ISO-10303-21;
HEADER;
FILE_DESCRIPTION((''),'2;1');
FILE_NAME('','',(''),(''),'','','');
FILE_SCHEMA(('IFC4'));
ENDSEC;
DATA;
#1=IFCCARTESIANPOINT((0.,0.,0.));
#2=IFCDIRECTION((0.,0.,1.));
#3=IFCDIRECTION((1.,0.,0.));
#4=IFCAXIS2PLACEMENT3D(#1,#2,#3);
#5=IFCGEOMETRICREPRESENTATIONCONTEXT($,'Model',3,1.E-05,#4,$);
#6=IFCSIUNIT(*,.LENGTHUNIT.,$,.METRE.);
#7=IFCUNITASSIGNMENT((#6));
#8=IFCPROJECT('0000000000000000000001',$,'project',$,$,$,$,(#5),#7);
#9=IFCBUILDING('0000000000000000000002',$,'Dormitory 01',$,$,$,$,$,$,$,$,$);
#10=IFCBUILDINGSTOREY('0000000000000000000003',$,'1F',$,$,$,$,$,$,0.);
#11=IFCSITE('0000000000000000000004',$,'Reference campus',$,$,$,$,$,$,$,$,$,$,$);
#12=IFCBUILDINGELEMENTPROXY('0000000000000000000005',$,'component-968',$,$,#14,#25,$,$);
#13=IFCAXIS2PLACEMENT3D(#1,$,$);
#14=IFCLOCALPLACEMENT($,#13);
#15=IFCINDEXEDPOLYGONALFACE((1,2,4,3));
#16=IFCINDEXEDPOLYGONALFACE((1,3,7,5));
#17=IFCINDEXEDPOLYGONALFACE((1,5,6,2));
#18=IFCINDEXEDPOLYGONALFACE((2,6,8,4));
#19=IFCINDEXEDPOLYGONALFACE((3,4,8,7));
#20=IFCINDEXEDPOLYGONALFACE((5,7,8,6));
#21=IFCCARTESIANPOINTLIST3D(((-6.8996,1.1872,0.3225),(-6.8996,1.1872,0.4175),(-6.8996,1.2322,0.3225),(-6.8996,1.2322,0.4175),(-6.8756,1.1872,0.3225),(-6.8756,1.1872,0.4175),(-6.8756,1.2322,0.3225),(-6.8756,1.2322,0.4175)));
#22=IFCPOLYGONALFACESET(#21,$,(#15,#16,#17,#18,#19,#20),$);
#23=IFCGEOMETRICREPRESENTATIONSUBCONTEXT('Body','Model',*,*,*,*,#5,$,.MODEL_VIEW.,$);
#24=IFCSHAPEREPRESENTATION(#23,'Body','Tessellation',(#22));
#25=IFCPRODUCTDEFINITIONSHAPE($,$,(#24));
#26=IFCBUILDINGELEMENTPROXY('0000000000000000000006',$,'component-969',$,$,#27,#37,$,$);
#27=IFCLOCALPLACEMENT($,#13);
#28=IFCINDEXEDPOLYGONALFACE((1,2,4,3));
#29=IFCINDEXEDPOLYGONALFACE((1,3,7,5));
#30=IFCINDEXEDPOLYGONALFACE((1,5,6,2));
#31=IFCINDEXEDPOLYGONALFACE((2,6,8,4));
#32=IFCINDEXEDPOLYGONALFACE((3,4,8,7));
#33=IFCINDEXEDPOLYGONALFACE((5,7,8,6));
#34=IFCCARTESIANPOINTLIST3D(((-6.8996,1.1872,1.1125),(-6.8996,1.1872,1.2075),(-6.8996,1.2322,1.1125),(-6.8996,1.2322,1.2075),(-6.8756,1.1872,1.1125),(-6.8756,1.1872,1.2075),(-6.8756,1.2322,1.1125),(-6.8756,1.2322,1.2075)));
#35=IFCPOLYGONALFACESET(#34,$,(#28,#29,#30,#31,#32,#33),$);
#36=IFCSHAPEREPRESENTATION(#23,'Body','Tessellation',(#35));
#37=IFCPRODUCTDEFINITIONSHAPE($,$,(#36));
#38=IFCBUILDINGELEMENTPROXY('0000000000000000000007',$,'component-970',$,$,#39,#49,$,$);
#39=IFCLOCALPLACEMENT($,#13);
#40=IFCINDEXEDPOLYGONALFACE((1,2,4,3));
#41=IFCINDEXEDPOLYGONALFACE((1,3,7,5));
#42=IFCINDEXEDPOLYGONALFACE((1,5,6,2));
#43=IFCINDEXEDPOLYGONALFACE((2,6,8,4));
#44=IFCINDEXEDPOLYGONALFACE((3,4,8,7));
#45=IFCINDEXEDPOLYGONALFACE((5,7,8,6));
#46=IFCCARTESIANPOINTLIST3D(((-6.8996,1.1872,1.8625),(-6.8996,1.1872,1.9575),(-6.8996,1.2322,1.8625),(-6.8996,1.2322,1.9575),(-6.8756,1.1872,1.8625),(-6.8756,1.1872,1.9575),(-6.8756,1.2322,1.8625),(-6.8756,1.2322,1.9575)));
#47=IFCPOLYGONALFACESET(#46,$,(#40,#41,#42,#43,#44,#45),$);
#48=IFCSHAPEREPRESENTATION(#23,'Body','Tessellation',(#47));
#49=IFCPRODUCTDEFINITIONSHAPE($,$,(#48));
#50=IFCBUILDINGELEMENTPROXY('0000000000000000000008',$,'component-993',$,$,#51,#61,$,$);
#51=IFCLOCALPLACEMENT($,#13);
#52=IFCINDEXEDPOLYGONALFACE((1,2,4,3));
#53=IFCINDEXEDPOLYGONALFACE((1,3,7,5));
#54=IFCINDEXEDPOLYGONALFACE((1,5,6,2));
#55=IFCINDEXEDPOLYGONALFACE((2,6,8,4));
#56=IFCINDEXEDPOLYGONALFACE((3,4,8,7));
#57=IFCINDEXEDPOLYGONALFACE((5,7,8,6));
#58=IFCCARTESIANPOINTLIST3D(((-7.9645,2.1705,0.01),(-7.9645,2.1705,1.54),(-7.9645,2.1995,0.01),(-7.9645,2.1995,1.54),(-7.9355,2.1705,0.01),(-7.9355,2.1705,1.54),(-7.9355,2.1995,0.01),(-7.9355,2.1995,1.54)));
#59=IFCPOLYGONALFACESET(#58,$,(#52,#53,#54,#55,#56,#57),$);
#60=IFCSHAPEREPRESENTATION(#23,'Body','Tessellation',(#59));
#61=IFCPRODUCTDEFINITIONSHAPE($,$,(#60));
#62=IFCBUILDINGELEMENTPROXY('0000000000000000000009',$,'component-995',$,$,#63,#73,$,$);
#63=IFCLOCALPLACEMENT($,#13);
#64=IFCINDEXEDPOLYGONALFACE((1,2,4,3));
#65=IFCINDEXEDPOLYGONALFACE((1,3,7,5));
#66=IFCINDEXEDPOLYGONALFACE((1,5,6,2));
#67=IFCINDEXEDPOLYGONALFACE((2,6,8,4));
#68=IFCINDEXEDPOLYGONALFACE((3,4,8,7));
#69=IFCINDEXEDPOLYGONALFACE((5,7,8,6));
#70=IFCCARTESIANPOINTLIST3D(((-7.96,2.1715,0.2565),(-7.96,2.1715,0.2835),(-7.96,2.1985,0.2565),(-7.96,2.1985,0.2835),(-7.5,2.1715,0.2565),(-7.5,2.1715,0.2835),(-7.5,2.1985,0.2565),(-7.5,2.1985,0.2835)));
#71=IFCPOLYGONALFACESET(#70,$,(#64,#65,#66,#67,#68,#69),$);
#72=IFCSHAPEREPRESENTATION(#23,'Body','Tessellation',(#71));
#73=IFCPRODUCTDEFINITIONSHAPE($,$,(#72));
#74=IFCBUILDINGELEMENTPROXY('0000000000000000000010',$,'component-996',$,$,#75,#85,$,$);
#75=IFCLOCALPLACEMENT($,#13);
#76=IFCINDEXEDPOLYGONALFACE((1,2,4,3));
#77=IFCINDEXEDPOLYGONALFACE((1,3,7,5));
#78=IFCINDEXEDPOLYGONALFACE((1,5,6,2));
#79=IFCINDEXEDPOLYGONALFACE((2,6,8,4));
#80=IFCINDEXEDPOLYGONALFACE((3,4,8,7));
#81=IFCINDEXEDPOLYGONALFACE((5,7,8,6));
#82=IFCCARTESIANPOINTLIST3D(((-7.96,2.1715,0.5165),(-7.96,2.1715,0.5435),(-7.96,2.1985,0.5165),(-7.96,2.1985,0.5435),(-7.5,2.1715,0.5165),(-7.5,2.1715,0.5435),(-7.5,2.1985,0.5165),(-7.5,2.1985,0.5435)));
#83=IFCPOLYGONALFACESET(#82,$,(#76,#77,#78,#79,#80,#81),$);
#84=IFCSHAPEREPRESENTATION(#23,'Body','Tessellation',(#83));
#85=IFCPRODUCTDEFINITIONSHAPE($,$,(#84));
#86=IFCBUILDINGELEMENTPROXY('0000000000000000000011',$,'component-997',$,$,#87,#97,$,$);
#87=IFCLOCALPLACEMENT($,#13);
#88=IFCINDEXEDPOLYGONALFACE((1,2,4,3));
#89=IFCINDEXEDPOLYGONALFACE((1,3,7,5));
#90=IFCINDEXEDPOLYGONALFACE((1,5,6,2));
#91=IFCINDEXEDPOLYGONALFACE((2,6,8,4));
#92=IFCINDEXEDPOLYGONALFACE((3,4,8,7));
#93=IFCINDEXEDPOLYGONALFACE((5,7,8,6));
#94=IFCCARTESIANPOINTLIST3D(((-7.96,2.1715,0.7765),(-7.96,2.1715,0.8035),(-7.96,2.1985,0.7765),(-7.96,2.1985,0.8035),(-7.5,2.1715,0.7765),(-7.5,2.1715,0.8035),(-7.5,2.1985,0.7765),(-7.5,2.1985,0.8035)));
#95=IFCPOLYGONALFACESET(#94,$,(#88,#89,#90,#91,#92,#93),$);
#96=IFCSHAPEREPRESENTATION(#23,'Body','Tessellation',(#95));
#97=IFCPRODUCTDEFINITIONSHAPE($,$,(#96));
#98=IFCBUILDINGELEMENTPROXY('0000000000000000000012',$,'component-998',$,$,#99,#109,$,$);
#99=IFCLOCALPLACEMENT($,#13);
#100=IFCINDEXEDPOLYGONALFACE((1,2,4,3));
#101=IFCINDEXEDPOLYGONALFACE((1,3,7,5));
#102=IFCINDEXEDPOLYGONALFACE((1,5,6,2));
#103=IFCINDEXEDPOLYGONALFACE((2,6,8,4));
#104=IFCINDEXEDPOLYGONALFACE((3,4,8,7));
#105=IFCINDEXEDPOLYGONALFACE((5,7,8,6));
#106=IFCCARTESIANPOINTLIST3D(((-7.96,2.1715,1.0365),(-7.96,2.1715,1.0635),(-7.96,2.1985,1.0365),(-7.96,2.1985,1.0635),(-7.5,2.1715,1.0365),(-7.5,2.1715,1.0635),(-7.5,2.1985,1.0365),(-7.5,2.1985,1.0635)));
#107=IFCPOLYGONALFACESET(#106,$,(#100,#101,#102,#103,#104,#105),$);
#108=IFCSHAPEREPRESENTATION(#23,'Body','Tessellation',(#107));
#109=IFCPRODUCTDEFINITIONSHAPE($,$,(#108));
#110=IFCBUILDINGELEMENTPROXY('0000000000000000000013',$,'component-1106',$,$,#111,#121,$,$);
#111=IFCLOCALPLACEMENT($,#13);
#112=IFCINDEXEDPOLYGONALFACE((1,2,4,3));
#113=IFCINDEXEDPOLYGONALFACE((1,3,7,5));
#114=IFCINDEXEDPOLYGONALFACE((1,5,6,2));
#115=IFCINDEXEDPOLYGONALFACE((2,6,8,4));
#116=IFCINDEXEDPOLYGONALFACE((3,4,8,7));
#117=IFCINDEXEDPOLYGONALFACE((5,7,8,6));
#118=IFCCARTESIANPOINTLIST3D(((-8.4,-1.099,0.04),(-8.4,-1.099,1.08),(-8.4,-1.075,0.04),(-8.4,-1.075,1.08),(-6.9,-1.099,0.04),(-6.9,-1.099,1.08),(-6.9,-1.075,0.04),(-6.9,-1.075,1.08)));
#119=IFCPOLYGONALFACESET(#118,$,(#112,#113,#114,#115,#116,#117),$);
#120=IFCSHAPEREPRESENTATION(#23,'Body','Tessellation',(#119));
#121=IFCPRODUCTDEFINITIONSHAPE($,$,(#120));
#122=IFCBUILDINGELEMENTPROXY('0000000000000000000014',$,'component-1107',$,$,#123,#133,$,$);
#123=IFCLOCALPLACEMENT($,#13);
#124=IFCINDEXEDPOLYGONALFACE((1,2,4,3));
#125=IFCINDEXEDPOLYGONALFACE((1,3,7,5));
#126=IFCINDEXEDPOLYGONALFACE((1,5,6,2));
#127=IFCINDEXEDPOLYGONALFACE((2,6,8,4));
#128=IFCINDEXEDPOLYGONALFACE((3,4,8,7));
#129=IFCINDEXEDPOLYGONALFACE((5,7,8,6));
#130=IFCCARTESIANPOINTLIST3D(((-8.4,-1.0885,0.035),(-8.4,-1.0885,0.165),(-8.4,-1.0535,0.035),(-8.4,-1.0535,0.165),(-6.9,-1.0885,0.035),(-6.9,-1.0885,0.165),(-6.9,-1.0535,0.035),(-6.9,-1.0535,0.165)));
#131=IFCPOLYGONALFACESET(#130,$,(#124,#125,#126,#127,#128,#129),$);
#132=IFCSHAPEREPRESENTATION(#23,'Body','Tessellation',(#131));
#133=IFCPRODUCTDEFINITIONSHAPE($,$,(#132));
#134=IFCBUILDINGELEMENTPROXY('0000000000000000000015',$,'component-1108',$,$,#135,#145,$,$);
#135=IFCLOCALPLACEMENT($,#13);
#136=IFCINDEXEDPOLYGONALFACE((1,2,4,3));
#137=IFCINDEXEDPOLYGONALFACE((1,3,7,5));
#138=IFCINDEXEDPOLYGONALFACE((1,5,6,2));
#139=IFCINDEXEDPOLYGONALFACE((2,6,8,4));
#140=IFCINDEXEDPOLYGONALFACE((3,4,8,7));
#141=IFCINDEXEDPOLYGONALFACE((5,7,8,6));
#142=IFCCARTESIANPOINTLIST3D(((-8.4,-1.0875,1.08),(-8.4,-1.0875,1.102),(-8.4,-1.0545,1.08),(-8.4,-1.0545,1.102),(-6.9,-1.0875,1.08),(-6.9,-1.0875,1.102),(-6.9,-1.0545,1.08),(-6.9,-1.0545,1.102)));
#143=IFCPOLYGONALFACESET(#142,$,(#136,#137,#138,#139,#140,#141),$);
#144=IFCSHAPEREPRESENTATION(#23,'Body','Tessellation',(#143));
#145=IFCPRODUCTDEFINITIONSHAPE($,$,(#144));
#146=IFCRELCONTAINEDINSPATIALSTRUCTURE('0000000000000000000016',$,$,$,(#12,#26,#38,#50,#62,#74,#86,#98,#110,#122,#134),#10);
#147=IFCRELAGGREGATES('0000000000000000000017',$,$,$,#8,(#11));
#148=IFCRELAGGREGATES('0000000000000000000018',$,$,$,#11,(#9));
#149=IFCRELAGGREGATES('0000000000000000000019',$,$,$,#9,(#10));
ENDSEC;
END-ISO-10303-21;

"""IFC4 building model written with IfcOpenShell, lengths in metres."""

from ifc_helpers import new_model, si_unit, frame, origin, origin_with_axes, origin_2d, place, context, subcontext, project, spatial, rectangle, extrude, element, save


model = new_model("IFC4")

# Units and contexts
model_context = context("Model", 3, precision=1e-05, world=origin_with_axes())
body_context = subcontext(model_context, "Body", "Model", "MODEL_VIEW")
ifc_project = project(units=[si_unit("LENGTHUNIT", "METRE")], contexts=[model_context])

# Site, building, storey
site = spatial("IfcSite", under=ifc_project, Name="Reference campus")
building = spatial("IfcBuilding", under=site, Name="Dormitory 01")
storey = spatial("IfcBuildingStorey", under=building, Name="1F", Elevation=0.0)

# Building element proxies
for number, where, z_axis, x_axis, name in (
    (1, (-6.8876, 1.2097, 0.3225), (0.0, 0.0, 1.0), (1.0, 0.0, 0.0), "component-968"),
    (2, (-6.8876, 1.2097, 1.1125), (0.0, 0.0, 1.0), (1.0, 0.0, 0.0), "component-969"),
    (3, (-6.8876, 1.2097, 1.8625), (0.0, 0.0, 1.0), (1.0, 0.0, 0.0), "component-970"),
):
    element("IfcBuildingElementProxy", number, at=place(None, frame(where, z_axis=z_axis, x_axis=x_axis)), inside=storey, Name=name, context=body_context, shape_type="SweptSolid", body=[
        extrude(rectangle(XDim=0.024, YDim=0.045, at=origin_2d()), origin(), (0.0, 0.0, 1.0), 0.095),
    ])
proxy_1_placement = place(None, frame((-7.95, 2.185, 0.01), z_axis=(0.0, 0.0, 1.0), x_axis=(1.0, 0.0, 0.0)))
element("IfcBuildingElementProxy", 4, at=proxy_1_placement, inside=storey, Name="component-993", context=body_context, shape_type="SweptSolid", body=[
    extrude(rectangle(XDim=0.029, YDim=0.029, at=origin_2d()), origin(), (0.0, 0.0, 1.0), 1.53),
])
for number, where, z_axis, x_axis, name in (
    (5, (-7.73, 2.185, 0.2565), (0.0, 0.0, 1.0), (1.0, 0.0, 0.0), "component-995"),
    (6, (-7.73, 2.185, 0.5165), (0.0, 0.0, 1.0), (1.0, 0.0, 0.0), "component-996"),
    (7, (-7.73, 2.185, 0.7765), (0.0, 0.0, 1.0), (1.0, 0.0, 0.0), "component-997"),
    (8, (-7.73, 2.185, 1.0365), (0.0, 0.0, 1.0), (1.0, 0.0, 0.0), "component-998"),
):
    element("IfcBuildingElementProxy", number, at=place(None, frame(where, z_axis=z_axis, x_axis=x_axis)), inside=storey, Name=name, context=body_context, shape_type="SweptSolid", body=[
        extrude(rectangle(XDim=0.46, YDim=0.027, at=origin_2d()), origin(), (0.0, 0.0, 1.0), 0.027),
    ])
proxy_2_placement = place(None, frame((-7.65, -1.087, 0.04), z_axis=(0.0, 0.0, 1.0), x_axis=(1.0, 0.0, 0.0)))
element("IfcBuildingElementProxy", 9, at=proxy_2_placement, inside=storey, Name="component-1106", context=body_context, shape_type="SweptSolid", body=[
    extrude(rectangle(XDim=1.5, YDim=0.024, at=origin_2d()), origin(), (0.0, 0.0, 1.0), 1.04),
])
proxy_3_placement = place(None, frame((-7.65, -1.071, 0.035), z_axis=(0.0, 0.0, 1.0), x_axis=(1.0, 0.0, 0.0)))
element("IfcBuildingElementProxy", 10, at=proxy_3_placement, inside=storey, Name="component-1107", context=body_context, shape_type="SweptSolid", body=[
    extrude(rectangle(XDim=1.5, YDim=0.035, at=origin_2d()), origin(), (0.0, 0.0, 1.0), 0.13),
])
proxy_4_placement = place(None, frame((-7.65, -1.071, 1.08), z_axis=(0.0, 0.0, 1.0), x_axis=(1.0, 0.0, 0.0)))
element("IfcBuildingElementProxy", 11, at=proxy_4_placement, inside=storey, Name="component-1108", context=body_context, shape_type="SweptSolid", body=[
    extrude(rectangle(XDim=1.5, YDim=0.033, at=origin_2d()), origin(), (0.0, 0.0, 1.0), 0.022),
])

save(model, "model.ifc")
